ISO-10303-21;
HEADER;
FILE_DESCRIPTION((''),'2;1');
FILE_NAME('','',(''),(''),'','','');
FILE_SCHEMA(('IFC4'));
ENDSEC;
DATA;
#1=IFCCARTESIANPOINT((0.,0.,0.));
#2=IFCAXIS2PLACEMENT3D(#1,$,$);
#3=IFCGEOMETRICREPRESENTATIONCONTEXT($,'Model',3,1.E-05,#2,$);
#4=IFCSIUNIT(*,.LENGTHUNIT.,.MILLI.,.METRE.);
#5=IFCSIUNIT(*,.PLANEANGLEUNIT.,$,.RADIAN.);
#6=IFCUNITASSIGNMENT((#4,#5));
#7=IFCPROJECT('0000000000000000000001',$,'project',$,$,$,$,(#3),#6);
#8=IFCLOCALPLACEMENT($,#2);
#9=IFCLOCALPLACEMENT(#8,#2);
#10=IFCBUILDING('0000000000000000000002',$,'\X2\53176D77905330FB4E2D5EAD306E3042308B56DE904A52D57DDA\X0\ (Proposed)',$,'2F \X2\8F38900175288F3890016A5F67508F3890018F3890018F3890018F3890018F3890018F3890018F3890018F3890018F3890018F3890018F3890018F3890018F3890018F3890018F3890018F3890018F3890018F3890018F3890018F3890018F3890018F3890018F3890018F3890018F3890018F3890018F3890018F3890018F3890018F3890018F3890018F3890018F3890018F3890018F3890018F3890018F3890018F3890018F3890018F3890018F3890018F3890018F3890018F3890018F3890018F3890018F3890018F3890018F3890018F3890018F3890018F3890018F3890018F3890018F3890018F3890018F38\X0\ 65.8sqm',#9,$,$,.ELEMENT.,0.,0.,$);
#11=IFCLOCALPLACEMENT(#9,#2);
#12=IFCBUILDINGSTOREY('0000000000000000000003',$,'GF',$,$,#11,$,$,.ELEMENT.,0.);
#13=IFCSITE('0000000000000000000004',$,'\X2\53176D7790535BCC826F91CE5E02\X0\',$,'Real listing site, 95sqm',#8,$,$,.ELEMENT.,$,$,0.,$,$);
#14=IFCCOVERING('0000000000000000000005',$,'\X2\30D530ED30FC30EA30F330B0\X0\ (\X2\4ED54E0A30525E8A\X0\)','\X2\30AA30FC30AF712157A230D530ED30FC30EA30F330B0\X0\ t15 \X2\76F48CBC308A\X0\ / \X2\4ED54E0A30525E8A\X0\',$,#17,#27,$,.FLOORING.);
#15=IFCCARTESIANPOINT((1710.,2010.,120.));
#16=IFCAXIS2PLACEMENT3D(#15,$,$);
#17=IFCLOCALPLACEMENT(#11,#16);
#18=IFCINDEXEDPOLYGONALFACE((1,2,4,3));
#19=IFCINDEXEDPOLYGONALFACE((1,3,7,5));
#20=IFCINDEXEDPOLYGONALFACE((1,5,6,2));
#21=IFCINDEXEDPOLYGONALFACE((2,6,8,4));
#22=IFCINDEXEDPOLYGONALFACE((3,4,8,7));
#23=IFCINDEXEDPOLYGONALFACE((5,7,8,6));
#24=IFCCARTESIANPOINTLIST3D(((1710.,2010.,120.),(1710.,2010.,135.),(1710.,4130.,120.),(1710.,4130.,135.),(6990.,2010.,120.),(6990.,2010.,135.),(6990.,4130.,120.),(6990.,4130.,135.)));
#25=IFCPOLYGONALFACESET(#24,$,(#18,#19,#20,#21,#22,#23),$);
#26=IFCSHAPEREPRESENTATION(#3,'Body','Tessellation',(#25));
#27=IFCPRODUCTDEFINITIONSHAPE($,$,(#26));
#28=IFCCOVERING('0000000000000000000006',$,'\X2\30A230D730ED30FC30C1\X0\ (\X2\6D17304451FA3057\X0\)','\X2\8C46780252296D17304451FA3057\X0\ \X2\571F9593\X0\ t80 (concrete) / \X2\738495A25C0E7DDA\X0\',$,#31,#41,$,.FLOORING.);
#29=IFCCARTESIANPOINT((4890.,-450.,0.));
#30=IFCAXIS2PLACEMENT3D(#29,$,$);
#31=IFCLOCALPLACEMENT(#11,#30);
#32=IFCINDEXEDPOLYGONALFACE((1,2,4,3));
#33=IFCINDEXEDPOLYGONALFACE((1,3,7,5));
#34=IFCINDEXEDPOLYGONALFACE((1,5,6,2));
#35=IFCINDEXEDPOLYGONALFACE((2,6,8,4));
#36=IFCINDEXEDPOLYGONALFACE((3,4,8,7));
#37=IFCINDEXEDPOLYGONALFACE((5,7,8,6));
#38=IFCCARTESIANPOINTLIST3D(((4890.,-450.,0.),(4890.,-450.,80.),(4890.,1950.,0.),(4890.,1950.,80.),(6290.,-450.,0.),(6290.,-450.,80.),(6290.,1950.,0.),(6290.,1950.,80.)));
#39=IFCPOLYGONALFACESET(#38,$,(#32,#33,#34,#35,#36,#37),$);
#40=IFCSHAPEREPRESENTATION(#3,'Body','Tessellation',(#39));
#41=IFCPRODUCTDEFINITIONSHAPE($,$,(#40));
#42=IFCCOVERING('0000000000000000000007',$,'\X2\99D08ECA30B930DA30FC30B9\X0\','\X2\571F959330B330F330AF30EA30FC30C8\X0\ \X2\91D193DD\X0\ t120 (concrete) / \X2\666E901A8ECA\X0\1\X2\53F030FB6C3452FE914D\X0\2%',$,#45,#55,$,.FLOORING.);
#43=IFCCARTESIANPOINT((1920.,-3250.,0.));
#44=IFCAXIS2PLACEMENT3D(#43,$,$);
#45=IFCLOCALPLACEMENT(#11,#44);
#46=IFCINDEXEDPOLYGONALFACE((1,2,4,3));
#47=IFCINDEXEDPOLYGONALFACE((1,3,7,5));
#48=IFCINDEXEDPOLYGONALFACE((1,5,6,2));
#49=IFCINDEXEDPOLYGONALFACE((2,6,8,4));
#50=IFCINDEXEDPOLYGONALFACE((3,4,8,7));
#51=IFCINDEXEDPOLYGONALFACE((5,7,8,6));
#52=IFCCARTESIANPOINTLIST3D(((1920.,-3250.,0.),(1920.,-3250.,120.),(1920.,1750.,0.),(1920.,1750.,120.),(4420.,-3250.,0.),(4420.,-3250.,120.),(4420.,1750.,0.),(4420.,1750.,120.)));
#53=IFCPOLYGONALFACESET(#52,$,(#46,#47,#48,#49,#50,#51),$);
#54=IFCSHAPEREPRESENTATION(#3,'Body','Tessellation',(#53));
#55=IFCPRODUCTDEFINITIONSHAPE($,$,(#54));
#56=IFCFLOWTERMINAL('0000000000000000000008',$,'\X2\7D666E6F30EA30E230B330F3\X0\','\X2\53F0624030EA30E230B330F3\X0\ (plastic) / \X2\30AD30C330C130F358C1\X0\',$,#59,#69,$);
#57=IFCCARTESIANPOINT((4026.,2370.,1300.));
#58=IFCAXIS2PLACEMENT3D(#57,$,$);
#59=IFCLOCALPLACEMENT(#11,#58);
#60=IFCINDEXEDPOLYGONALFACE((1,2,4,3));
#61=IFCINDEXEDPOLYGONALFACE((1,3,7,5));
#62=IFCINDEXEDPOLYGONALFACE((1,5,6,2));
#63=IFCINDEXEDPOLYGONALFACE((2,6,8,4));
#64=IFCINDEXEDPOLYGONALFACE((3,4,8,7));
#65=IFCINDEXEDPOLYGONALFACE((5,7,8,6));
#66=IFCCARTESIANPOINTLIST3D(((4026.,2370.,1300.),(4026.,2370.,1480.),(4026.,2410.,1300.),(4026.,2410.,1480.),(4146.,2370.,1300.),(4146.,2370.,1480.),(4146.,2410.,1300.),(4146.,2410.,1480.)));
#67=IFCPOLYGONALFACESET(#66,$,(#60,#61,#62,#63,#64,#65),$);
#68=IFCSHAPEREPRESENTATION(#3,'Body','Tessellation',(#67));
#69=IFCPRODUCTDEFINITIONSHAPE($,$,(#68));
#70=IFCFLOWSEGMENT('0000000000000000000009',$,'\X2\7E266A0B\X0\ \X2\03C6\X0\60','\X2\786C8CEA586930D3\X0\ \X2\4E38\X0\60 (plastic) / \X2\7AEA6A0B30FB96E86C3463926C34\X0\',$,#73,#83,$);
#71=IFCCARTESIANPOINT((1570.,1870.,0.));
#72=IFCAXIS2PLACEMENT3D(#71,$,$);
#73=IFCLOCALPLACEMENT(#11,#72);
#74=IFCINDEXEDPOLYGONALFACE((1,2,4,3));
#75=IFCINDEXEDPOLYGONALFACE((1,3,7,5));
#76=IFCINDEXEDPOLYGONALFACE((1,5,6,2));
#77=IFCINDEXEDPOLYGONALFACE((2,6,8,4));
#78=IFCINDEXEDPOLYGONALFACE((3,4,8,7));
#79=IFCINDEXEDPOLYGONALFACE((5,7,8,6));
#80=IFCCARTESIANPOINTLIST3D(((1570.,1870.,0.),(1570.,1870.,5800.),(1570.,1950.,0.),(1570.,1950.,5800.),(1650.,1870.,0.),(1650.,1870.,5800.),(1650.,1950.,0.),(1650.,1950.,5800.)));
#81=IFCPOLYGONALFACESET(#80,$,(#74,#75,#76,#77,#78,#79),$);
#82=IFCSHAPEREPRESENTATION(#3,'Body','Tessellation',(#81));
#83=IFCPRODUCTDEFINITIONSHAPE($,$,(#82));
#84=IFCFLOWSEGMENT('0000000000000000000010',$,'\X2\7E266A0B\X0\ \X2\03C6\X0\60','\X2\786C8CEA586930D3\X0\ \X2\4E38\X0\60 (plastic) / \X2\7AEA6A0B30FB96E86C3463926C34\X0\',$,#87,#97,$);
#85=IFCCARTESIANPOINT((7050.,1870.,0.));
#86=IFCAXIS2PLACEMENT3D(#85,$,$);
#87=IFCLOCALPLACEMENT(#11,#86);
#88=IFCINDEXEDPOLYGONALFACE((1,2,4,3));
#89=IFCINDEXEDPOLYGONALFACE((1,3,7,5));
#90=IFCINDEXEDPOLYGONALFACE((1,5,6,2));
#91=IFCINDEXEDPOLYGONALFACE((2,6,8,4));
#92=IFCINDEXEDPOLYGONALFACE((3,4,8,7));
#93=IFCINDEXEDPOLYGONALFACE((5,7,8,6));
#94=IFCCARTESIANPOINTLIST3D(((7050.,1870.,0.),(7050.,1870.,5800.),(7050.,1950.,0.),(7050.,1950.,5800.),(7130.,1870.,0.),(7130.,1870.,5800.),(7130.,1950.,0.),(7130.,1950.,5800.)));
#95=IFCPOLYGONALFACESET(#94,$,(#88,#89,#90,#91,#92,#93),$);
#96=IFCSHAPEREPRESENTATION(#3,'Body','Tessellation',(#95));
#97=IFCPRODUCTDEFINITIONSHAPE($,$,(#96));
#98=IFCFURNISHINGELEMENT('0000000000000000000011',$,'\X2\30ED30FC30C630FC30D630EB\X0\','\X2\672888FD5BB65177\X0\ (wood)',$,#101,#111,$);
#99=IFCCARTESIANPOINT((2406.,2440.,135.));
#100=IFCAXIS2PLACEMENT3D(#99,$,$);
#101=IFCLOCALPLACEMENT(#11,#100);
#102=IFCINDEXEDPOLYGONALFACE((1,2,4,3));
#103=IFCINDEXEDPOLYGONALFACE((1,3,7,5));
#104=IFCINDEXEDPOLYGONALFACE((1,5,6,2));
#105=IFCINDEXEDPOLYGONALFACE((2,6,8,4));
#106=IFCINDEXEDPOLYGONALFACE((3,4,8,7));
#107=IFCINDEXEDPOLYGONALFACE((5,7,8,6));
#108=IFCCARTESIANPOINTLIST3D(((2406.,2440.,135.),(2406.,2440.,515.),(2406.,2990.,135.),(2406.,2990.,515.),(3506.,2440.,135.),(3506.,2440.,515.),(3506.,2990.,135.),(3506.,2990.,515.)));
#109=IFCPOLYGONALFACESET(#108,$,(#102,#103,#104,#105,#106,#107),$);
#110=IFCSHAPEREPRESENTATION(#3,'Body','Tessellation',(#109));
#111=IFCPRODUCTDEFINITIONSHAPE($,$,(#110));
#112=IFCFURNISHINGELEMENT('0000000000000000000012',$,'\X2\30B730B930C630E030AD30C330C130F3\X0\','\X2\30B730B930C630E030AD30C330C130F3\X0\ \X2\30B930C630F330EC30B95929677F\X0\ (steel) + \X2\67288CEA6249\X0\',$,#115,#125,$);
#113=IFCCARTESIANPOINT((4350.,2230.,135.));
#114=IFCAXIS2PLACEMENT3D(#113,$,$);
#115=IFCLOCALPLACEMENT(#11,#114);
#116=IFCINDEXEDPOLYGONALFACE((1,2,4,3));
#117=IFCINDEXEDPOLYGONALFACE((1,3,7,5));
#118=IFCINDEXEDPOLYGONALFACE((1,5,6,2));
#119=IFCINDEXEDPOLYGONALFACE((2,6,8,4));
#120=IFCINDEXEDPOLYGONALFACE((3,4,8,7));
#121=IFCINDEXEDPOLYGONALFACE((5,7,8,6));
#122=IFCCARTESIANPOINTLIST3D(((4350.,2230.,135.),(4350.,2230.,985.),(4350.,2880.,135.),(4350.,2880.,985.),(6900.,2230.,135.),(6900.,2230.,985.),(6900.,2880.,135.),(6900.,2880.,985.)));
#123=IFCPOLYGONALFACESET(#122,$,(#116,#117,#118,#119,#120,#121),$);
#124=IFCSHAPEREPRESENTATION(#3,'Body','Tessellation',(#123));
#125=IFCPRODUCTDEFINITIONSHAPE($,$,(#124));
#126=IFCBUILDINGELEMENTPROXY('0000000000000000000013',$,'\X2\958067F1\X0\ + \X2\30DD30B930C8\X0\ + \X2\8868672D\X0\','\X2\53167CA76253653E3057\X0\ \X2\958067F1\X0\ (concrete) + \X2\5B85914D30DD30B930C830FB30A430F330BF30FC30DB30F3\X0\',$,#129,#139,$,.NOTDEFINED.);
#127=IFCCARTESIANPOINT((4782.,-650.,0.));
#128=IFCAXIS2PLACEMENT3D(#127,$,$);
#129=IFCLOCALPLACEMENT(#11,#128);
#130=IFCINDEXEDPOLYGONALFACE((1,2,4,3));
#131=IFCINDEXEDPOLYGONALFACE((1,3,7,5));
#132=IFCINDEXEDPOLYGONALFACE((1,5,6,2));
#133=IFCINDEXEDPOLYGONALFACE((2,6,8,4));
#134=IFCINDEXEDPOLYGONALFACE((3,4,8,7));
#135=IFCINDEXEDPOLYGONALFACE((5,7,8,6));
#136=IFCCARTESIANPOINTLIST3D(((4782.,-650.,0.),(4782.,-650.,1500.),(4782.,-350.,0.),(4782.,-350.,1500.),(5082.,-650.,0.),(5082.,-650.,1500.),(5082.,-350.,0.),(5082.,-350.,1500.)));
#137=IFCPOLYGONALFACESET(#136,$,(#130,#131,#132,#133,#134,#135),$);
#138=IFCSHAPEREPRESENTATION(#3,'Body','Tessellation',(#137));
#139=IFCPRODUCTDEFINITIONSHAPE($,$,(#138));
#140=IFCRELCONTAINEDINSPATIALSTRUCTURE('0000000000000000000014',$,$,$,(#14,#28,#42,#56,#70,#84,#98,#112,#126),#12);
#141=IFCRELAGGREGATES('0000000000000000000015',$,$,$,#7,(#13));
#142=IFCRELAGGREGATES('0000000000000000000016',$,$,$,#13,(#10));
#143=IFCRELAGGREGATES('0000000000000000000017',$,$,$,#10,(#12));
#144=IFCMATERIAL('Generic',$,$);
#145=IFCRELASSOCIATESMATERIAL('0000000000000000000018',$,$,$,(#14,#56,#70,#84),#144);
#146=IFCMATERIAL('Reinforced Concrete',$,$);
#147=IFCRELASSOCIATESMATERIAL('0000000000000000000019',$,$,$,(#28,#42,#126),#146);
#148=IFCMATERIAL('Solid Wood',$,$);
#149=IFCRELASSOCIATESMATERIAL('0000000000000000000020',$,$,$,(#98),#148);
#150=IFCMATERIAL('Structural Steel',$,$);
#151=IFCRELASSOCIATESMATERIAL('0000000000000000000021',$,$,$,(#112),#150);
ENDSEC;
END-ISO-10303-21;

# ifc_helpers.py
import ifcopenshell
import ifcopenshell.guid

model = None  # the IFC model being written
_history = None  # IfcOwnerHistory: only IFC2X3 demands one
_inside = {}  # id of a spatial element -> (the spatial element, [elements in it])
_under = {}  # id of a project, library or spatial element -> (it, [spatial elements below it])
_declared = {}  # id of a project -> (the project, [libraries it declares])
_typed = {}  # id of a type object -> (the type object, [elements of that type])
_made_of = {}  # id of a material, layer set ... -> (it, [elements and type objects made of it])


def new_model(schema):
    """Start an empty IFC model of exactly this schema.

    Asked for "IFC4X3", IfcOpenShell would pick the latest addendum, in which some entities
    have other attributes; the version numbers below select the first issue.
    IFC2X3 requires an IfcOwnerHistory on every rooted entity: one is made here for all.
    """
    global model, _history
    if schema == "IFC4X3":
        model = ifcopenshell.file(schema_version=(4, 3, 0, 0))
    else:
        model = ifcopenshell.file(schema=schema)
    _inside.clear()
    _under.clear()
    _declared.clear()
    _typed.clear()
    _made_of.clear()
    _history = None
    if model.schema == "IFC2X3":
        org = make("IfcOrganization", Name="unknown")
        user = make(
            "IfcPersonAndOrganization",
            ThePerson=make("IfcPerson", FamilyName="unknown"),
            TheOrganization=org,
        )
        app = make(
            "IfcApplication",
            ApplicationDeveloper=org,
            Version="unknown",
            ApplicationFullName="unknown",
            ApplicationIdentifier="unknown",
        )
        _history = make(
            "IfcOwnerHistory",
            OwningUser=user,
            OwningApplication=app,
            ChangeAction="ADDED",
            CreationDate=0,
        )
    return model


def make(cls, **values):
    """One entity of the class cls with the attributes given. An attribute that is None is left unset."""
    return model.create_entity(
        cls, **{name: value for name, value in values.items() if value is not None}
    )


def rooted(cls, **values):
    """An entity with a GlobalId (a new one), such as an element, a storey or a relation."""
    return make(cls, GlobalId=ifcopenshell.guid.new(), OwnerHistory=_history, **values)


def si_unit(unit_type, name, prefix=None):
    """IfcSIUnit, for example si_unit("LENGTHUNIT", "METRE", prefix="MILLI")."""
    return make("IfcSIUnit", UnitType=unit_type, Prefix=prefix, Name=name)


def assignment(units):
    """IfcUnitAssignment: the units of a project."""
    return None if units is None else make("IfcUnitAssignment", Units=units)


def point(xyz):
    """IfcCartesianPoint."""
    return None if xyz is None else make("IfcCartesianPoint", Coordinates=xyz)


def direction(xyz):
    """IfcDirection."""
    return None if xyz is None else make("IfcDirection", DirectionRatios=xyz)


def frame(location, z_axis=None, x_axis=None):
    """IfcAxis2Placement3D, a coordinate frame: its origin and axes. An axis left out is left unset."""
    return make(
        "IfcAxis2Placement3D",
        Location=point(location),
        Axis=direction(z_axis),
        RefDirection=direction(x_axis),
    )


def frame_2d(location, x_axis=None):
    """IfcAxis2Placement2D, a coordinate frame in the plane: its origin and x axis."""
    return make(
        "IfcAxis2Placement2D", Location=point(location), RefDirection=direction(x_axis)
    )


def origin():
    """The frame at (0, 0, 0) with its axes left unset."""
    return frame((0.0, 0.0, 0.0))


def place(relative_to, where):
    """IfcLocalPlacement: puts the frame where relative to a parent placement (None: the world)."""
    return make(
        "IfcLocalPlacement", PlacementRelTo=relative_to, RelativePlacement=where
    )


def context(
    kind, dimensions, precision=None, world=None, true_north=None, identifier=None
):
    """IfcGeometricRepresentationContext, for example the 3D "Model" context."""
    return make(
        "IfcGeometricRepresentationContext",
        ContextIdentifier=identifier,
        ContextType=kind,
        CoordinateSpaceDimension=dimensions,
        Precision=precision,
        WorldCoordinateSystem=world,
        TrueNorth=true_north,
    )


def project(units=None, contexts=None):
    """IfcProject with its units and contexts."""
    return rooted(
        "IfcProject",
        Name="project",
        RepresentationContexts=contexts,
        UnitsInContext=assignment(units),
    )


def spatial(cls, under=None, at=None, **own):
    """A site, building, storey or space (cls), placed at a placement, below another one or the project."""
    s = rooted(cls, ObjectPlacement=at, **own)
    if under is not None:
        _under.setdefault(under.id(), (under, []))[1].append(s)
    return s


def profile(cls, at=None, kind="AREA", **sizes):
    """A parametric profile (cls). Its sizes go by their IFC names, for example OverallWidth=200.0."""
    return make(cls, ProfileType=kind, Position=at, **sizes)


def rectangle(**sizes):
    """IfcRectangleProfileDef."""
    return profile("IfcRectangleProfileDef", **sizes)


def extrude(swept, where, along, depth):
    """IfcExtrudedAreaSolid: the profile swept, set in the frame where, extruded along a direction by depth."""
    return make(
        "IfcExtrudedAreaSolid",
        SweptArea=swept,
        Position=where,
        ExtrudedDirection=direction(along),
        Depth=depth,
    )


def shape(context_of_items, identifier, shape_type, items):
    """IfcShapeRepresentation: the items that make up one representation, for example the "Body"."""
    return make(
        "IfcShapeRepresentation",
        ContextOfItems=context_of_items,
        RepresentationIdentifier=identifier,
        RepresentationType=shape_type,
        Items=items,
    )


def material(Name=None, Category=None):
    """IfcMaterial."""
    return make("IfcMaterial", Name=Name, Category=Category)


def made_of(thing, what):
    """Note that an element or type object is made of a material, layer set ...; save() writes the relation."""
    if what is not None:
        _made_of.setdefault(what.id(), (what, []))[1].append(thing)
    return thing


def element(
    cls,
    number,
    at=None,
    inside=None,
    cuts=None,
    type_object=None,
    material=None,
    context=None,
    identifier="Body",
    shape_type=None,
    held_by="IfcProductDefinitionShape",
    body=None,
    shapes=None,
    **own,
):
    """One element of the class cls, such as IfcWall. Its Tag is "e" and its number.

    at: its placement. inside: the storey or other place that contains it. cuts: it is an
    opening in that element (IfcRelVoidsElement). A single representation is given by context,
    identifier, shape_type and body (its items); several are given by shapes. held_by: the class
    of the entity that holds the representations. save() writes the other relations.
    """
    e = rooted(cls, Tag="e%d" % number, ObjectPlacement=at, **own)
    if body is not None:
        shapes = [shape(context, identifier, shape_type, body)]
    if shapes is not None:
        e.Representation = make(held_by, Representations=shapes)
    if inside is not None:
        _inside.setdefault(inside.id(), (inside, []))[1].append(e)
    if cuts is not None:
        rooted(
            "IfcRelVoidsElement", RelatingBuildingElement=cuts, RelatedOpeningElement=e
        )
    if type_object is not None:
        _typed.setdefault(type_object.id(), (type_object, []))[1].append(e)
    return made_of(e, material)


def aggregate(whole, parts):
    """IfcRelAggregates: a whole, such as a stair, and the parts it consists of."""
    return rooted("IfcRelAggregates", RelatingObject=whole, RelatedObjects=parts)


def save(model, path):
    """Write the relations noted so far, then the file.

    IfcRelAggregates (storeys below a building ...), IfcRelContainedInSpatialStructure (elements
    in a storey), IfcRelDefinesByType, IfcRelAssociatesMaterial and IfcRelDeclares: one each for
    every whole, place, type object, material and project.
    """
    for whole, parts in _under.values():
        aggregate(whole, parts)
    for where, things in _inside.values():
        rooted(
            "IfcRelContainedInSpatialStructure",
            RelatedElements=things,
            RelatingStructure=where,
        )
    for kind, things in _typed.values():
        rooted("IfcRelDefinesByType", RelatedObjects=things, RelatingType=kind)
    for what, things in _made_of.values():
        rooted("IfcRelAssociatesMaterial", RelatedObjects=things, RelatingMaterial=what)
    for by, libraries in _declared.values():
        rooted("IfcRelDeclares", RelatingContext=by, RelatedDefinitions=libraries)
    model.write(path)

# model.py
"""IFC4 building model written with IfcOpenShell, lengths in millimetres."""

from ifc_helpers import new_model, si_unit, frame, frame_2d, origin, place, context, project, spatial, rectangle, extrude, material, element, save


model = new_model("IFC4")

# Units and contexts
model_context = context("Model", 3, precision=1e-05, world=origin())
ifc_project = project(units=[si_unit("LENGTHUNIT", "METRE", prefix="MILLI"), si_unit("PLANEANGLEUNIT", "RADIAN")], contexts=[model_context])

# Site, building, storey
site_placement = place(None, origin())
site = spatial("IfcSite", under=ifc_project, at=site_placement, Name="北海道富良野市", ObjectType="Real listing site, 95sqm", CompositionType="ELEMENT", RefElevation=0.0)
building_placement = place(site_placement, origin())
building = spatial("IfcBuilding", under=site, at=building_placement, Name="北海道・中庭のある回遊動線 (Proposed)", ObjectType="2F 輸送用輸送機材輸送輸送輸送輸送輸送輸送輸送輸送輸送輸送輸送輸送輸送輸送輸送輸送輸送輸送輸送輸送輸送輸送輸送輸送輸送輸送輸送輸送輸送輸送輸送輸送輸送輸送輸送輸送輸送輸送輸送輸送輸送輸送輸送輸送輸送輸送輸送輸送輸送輸送輸送輸送輸送輸送輸送輸送輸 65.8sqm", CompositionType="ELEMENT", ElevationOfRefHeight=0.0, ElevationOfTerrain=0.0)
storey_placement = place(building_placement, origin())
storey = spatial("IfcBuildingStorey", under=building, at=storey_placement, Name="GF", CompositionType="ELEMENT", Elevation=0.0)

# Shared definitions
ifc_material_1 = material(Name="Solid Wood")

# Shared definitions
ifc_material_2 = material(Name="Reinforced Concrete")

# Coverings
ifc_material_3 = material(Name="Generic")
covering_1_placement = place(storey_placement, frame((1710.0, 2010.0, 120.0)))
element("IfcCovering", 1, at=covering_1_placement, inside=storey, material=ifc_material_3, Name="フローリング (仕上げ床)", Description="オーク無垢フローリング t15 直貼り / 仕上げ床", PredefinedType="FLOORING", context=model_context, shape_type="SweptSolid", body=[
    extrude(rectangle(XDim=5280.0, YDim=2120.0, at=frame_2d((2640.0, 1060.0))), frame((1710.0, 2010.0, 120.0)), (0.0, 0.0, 1.0), 15.0),
])
covering_2_placement = place(storey_placement, frame((4890.0, -450.0, 0.0)))
element("IfcCovering", 2, at=covering_2_placement, inside=storey, material=ifc_material_2, Name="アプローチ (洗い出し)", Description="豆砂利洗い出し 土間 t80 (concrete) / 玄関導線", PredefinedType="FLOORING", context=model_context, shape_type="SweptSolid", body=[
    extrude(rectangle(XDim=1400.0, YDim=2400.0, at=frame_2d((700.0, 1200.0))), frame((4890.0, -450.0, 0.0)), (0.0, 0.0, 1.0), 80.0),
])
covering_3_placement = place(storey_placement, frame((1920.0, -3250.0, 0.0)))
element("IfcCovering", 3, at=covering_3_placement, inside=storey, material=ifc_material_2, Name="駐車スペース", Description="土間コンクリート 金鏝 t120 (concrete) / 普通車1台・水勾配2%", PredefinedType="FLOORING", context=model_context, shape_type="SweptSolid", body=[
    extrude(rectangle(XDim=2500.0, YDim=5000.0, at=frame_2d((1250.0, 2500.0))), frame((1920.0, -3250.0, 0.0)), (0.0, 0.0, 1.0), 120.0),
])

# Flow terminal
flow_terminal_placement = place(storey_placement, frame((4026.0, 2370.0, 1300.0)))
element("IfcFlowTerminal", 4, at=flow_terminal_placement, inside=storey, material=ifc_material_3, Name="給湯リモコン", Description="台所リモコン (plastic) / キッチン壁", context=model_context, shape_type="SweptSolid", body=[
    extrude(rectangle(XDim=120.0, YDim=40.0, at=frame_2d((60.0, 20.0))), frame((4026.0, 2370.0, 1300.0)), (0.0, 0.0, 1.0), 180.0),
])

# Flow segments
flow_segment_1_placement = place(storey_placement, frame((1570.0, 1870.0, 0.0)))
element("IfcFlowSegment", 5, at=flow_segment_1_placement, inside=storey, material=ifc_material_3, Name="縦樋 φ60", Description="硬質塩ビ 丸60 (plastic) / 竪樋・雨水排水", context=model_context, shape_type="SweptSolid", body=[
    extrude(rectangle(XDim=80.0, YDim=80.0, at=frame_2d((40.0, 40.0))), frame((1570.0, 1870.0, 0.0)), (0.0, 0.0, 1.0), 5800.0),
])
flow_segment_2_placement = place(storey_placement, frame((7050.0, 1870.0, 0.0)))
element("IfcFlowSegment", 6, at=flow_segment_2_placement, inside=storey, material=ifc_material_3, Name="縦樋 φ60", Description="硬質塩ビ 丸60 (plastic) / 竪樋・雨水排水", context=model_context, shape_type="SweptSolid", body=[
    extrude(rectangle(XDim=80.0, YDim=80.0, at=frame_2d((40.0, 40.0))), frame((7050.0, 1870.0, 0.0)), (0.0, 0.0, 1.0), 5800.0),
])

# Furnishing elements
furnishing_1_placement = place(storey_placement, frame((2406.0, 2440.0, 135.0)))
element("IfcFurnishingElement", 7, at=furnishing_1_placement, inside=storey, material=ifc_material_1, Name="ローテーブル", Description="木製家具 (wood)", context=model_context, shape_type="SweptSolid", body=[
    extrude(rectangle(XDim=1100.0, YDim=550.0, at=frame_2d((550.0, 275.0))), frame((2406.0, 2440.0, 135.0)), (0.0, 0.0, 1.0), 380.0),
])
ifc_material_4 = material(Name="Structural Steel")
furnishing_2_placement = place(storey_placement, frame((4350.0, 2230.0, 135.0)))
element("IfcFurnishingElement", 8, at=furnishing_2_placement, inside=storey, material=ifc_material_4, Name="システムキッチン", Description="システムキッチン ステンレス天板 (steel) + 木質扉", context=model_context, shape_type="SweptSolid", body=[
    extrude(rectangle(XDim=2550.0, YDim=650.0, at=frame_2d((1275.0, 325.0))), frame((4350.0, 2230.0, 135.0)), (0.0, 0.0, 1.0), 850.0),
])

# Building element proxy
proxy_placement = place(storey_placement, frame((4782.0, -650.0, 0.0)))
element("IfcBuildingElementProxy", 9, at=proxy_placement, inside=storey, material=ifc_material_2, Name="門柱 + ポスト + 表札", Description="化粧打放し 門柱 (concrete) + 宅配ポスト・インターホン", PredefinedType="NOTDEFINED", context=model_context, shape_type="SweptSolid", body=[
    extrude(rectangle(XDim=300.0, YDim=300.0, at=frame_2d((150.0, 150.0))), frame((4782.0, -650.0, 0.0)), (0.0, 0.0, 1.0), 1500.0),
])

save(model, "model.ifc")
